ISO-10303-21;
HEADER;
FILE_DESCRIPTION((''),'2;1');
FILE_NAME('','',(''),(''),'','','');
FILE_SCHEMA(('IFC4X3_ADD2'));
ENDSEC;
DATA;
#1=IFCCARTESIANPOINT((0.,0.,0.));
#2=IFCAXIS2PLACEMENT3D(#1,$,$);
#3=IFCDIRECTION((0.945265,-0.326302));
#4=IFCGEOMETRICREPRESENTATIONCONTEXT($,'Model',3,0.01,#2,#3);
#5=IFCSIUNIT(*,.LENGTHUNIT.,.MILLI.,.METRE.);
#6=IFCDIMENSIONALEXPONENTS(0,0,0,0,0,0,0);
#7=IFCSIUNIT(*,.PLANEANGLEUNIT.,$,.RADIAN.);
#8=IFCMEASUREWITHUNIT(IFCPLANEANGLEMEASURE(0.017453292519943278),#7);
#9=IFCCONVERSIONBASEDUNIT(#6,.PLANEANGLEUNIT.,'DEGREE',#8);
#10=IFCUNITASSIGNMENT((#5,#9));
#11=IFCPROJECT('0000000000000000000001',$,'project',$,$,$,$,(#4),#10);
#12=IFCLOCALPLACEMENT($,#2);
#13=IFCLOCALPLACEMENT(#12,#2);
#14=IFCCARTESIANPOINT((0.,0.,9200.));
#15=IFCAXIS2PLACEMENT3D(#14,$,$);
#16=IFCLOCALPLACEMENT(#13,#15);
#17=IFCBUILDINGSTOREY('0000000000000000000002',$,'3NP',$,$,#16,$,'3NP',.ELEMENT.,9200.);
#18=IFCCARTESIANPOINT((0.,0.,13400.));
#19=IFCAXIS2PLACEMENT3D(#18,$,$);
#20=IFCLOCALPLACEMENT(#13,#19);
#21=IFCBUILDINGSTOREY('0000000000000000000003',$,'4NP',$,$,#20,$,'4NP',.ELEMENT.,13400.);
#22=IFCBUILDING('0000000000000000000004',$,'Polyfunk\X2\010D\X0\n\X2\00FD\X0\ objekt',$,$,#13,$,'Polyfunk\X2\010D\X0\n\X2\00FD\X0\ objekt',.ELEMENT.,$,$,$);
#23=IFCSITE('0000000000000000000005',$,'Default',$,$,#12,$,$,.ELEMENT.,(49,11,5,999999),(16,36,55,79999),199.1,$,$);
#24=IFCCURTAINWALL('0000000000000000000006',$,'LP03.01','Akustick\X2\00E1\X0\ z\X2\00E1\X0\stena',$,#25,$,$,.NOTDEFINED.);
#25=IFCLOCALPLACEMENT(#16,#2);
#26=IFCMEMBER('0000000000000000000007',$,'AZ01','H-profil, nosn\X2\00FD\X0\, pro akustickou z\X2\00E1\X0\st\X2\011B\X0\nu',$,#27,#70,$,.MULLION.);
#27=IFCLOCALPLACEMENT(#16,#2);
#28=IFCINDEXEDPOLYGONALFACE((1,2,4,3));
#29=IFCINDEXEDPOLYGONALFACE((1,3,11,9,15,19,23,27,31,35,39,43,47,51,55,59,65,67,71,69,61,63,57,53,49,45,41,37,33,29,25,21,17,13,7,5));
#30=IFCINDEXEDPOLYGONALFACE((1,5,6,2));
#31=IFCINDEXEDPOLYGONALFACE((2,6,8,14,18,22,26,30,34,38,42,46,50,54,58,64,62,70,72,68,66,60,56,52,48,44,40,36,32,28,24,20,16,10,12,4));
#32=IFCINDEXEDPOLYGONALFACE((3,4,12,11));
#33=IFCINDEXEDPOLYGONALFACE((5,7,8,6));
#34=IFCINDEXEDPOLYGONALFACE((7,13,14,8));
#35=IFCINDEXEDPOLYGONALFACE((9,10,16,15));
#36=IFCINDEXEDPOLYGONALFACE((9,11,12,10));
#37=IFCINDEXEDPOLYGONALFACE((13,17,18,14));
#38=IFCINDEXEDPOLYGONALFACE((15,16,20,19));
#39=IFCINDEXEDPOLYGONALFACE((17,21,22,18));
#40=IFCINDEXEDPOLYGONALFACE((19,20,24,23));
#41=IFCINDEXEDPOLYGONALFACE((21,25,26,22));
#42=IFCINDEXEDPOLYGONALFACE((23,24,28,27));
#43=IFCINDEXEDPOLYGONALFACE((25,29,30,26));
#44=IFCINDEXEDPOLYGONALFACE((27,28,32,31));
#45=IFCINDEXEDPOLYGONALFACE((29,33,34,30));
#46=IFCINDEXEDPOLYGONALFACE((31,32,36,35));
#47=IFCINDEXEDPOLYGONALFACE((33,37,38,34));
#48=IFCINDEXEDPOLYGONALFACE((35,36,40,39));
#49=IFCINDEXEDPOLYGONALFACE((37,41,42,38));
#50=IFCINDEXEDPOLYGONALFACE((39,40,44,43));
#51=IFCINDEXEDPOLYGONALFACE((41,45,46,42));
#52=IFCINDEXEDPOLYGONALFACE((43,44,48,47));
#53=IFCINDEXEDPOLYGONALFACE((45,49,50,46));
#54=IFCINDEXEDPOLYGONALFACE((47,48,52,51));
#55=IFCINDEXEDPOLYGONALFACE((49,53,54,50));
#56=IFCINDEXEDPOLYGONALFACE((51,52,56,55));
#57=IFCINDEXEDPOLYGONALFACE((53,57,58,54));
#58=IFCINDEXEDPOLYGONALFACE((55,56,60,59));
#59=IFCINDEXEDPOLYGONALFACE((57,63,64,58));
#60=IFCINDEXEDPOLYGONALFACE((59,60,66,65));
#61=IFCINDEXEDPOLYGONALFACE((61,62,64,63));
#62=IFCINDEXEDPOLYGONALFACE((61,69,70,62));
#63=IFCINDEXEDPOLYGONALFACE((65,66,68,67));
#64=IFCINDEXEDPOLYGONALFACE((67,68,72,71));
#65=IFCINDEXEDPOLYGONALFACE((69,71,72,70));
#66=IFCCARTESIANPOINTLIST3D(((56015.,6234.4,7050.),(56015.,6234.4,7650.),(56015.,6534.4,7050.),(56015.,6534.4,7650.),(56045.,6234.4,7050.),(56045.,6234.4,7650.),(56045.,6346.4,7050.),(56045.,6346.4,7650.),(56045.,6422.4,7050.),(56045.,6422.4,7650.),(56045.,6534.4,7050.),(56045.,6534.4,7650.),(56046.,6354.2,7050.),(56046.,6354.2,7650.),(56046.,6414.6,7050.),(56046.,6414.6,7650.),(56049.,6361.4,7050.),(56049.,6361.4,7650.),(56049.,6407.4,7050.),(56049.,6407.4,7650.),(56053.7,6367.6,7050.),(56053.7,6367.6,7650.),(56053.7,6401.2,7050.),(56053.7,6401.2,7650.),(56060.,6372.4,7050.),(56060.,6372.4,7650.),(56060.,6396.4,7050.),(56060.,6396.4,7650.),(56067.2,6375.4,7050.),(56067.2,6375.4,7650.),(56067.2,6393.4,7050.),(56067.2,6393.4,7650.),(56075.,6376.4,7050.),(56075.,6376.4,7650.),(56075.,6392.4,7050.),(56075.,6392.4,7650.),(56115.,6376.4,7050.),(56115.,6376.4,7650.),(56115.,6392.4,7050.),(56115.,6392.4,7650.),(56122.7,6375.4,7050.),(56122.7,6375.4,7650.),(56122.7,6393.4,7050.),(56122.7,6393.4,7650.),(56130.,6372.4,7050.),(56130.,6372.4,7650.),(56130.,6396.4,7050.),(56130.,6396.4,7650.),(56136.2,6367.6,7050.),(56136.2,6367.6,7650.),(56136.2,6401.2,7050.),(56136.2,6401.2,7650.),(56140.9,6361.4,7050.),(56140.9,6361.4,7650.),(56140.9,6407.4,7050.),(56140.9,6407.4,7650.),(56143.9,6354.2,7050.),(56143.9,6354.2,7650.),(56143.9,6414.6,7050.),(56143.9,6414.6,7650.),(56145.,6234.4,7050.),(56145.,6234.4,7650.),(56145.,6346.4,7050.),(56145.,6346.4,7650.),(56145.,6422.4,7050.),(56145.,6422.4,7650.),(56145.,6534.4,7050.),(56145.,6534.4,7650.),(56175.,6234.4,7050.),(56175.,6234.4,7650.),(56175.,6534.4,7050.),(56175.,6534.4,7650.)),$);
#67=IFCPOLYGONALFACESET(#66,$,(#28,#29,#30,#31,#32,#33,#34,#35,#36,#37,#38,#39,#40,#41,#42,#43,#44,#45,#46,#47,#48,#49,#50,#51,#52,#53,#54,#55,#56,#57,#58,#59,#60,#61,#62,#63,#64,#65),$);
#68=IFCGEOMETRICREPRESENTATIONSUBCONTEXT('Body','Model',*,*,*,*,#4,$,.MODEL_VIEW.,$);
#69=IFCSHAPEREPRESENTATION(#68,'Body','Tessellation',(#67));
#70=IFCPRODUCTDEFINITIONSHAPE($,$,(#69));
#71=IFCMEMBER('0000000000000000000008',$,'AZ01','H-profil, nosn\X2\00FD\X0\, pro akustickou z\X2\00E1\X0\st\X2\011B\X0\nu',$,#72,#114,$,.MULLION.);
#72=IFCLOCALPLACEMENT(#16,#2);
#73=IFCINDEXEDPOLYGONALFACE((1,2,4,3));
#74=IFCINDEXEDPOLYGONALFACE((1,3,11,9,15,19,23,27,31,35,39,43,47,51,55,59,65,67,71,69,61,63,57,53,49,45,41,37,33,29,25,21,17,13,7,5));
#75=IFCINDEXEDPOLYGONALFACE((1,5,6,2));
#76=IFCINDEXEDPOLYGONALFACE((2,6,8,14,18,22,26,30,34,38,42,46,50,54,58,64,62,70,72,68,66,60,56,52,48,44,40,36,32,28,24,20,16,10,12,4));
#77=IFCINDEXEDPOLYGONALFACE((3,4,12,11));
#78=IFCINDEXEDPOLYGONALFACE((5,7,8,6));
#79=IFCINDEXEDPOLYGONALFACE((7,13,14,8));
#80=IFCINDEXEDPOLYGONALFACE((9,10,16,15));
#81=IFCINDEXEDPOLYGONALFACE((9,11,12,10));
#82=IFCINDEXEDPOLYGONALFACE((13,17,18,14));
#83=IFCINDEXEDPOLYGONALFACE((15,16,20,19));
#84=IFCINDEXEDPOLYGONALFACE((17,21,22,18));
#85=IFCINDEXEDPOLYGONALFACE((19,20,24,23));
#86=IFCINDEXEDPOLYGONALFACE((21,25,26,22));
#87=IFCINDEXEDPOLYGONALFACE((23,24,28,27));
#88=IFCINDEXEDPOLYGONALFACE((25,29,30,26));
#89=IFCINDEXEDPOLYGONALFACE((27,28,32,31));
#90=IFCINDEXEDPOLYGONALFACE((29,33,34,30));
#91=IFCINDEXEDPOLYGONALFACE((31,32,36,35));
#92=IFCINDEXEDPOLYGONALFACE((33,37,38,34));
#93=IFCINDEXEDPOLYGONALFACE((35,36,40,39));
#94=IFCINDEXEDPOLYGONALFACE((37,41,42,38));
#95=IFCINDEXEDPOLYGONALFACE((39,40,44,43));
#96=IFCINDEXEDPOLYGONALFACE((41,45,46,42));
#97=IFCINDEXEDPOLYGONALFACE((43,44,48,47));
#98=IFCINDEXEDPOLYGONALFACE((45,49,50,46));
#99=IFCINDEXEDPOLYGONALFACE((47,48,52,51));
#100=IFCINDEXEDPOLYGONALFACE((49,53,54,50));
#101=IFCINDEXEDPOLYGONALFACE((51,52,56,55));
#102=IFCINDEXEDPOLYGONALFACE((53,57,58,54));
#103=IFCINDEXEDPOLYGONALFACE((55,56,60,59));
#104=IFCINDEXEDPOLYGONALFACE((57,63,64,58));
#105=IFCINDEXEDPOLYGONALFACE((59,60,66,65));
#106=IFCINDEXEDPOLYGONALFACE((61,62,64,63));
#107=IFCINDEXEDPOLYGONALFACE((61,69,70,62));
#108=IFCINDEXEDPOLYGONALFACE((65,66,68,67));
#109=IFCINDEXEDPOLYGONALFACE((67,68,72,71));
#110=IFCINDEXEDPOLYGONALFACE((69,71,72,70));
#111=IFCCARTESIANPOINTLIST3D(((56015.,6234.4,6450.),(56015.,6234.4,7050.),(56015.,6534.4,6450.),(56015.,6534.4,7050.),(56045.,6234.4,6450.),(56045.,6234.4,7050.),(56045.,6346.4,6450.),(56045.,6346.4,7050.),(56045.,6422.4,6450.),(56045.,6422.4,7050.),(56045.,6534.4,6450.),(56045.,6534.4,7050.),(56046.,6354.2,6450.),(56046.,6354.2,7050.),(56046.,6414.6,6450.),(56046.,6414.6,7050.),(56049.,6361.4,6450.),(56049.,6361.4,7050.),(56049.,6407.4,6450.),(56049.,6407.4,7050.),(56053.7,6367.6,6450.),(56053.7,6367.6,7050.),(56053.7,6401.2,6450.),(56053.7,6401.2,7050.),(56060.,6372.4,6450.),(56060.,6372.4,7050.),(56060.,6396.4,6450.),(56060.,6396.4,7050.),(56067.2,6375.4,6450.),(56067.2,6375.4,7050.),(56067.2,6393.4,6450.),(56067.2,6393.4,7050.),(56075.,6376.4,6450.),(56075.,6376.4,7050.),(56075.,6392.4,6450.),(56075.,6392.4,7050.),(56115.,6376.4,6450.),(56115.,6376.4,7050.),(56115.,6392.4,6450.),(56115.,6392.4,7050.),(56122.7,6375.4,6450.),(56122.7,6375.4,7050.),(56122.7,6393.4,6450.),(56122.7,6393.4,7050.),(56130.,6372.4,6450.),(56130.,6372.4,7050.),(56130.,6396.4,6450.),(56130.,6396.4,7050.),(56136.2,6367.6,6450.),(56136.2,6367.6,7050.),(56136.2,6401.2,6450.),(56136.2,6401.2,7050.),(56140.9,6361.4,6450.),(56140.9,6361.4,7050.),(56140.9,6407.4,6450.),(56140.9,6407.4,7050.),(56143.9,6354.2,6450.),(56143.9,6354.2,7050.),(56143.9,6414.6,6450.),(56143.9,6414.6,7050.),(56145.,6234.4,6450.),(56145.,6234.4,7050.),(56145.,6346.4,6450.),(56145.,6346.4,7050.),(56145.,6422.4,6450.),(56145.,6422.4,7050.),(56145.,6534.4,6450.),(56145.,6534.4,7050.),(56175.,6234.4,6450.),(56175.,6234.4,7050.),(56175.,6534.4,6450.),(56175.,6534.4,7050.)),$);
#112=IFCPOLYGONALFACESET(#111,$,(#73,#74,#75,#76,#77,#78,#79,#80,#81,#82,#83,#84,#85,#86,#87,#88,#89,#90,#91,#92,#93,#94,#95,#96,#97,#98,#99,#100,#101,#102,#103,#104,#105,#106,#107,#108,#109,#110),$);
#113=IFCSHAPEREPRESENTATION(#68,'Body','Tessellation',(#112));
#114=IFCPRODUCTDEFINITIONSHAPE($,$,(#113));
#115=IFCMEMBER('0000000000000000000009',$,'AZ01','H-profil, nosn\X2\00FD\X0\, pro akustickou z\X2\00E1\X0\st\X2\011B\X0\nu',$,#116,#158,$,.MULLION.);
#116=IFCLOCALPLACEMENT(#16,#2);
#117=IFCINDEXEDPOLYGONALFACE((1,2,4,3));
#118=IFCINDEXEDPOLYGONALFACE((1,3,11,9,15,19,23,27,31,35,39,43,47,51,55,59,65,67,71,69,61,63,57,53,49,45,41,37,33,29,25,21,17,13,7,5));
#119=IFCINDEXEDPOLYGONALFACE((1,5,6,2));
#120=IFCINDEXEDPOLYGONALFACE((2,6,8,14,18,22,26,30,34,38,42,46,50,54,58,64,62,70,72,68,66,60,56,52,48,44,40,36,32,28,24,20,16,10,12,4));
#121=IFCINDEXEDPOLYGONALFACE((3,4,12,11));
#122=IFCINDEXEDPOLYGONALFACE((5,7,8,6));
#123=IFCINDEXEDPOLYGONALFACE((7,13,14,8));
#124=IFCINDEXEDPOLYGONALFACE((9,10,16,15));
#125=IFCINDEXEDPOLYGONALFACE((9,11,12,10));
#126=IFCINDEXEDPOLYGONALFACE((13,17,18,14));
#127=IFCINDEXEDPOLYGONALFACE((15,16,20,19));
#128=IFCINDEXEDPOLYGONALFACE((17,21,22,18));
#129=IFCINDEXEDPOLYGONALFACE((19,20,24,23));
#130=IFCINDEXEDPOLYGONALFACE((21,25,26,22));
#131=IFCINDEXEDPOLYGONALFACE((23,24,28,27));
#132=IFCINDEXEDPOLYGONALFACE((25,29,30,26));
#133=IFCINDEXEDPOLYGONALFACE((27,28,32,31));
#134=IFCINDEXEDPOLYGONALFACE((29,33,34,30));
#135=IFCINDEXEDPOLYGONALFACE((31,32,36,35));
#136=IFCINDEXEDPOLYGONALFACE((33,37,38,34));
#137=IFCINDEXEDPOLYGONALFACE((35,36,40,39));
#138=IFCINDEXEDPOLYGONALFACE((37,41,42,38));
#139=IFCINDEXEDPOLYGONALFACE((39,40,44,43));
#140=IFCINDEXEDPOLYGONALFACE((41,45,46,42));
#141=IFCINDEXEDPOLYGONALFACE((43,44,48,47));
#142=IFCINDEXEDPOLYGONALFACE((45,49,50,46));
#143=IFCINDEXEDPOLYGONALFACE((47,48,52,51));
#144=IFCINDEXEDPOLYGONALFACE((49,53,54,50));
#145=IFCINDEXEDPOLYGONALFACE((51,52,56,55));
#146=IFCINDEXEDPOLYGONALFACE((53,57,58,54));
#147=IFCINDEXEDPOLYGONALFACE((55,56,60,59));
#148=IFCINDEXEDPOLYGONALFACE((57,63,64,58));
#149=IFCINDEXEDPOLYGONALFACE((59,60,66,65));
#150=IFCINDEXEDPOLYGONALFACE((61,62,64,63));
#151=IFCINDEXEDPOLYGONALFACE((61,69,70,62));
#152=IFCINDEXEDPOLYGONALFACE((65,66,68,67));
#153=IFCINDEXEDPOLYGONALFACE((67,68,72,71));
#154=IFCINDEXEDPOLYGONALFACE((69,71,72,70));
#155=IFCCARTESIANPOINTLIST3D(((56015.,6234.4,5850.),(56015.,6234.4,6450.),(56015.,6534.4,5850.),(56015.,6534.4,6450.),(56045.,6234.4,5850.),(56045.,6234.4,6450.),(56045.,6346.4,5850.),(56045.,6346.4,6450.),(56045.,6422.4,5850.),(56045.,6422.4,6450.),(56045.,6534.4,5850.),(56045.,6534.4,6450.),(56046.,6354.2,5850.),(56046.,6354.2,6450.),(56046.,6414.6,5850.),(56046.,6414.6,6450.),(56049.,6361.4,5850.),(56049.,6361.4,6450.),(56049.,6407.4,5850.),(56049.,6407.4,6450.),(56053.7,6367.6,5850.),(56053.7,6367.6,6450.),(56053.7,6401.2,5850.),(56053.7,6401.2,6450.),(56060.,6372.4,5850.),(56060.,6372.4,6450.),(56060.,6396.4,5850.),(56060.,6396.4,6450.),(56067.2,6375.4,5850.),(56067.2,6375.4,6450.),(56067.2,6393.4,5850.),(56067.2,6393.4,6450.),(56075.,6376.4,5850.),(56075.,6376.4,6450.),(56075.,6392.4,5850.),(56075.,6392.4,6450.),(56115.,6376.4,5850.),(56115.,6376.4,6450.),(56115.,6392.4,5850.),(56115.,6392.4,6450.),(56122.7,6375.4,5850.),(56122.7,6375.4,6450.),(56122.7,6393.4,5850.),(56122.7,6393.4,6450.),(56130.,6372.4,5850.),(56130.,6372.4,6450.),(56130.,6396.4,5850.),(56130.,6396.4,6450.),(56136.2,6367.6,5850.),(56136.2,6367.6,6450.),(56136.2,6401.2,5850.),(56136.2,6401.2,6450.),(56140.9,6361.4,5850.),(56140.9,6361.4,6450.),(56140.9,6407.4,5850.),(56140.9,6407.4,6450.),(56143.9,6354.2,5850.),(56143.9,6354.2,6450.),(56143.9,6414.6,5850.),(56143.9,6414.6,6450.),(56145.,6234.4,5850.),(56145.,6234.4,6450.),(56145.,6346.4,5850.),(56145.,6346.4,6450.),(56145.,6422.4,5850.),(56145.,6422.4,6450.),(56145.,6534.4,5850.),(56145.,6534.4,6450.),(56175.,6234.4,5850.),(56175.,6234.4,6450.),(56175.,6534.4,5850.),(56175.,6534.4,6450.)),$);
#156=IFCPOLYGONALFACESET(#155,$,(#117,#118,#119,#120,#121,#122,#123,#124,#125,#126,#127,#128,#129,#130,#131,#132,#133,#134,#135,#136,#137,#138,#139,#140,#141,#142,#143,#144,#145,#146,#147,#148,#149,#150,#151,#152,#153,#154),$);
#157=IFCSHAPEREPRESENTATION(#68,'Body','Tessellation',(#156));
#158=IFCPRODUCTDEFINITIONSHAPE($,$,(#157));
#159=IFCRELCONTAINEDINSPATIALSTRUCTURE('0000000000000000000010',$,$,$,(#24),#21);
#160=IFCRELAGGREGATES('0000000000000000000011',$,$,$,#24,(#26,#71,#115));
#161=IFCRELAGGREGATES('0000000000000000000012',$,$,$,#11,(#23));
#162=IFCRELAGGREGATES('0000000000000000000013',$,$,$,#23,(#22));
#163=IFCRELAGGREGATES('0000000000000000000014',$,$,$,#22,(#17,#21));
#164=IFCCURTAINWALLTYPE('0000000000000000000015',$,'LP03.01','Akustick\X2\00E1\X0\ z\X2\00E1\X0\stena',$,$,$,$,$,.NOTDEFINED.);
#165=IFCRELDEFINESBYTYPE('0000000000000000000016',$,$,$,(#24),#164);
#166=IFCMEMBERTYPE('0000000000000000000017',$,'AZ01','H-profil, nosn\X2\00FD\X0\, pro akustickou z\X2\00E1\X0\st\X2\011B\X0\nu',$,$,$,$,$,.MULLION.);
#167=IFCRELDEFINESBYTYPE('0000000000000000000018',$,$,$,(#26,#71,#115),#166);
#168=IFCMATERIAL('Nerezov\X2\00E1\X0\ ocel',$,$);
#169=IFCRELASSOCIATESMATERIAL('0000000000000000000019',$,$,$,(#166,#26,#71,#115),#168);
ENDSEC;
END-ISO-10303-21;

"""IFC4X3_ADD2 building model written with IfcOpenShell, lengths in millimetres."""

from ifc_helpers import new_model, entity, si_unit, converted_unit, direction, frame, frame_2d, origin, place, context, subcontext, project, spatial, polyline, circle_curve, parameter, trimmed, segment, composite_curve, outline, extrude, source, transform, mapped, material, material_profile, profile_set, profile_usage, type_object, element, aggregate, save


model = new_model("IFC4X3_ADD2")

# Units and contexts
model_context = context("Model", 3, precision=0.01, world=origin(), true_north=direction((0.945265, -0.326302)))
body_context = subcontext(model_context, "Body", "Model", "MODEL_VIEW")
ifc_project = project(units=[si_unit("LENGTHUNIT", "METRE", prefix="MILLI"), converted_unit("PLANEANGLEUNIT", "DEGREE", entity("IfcPlaneAngleMeasure", 0.017453292519943278), si_unit("PLANEANGLEUNIT", "RADIAN"), dimensions=[0, 0, 0, 0, 0, 0, 0])], contexts=[model_context])

# Site, building, storey
site_placement = place(None, origin())
site = spatial("IfcSite", under=ifc_project, at=site_placement, Name="Default", CompositionType="ELEMENT", RefLatitude=(49, 11, 5, 999999), RefLongitude=(16, 36, 55, 79999), RefElevation=199.1)
building_placement = place(site_placement, origin())
building = spatial("IfcBuilding", under=site, at=building_placement, Name="Polyfunkčný objekt", LongName="Polyfunkčný objekt", CompositionType="ELEMENT")
storey_1_placement = place(building_placement, frame((0.0, 0.0, 9200.0)))
storey_1 = spatial("IfcBuildingStorey", under=building, at=storey_1_placement, Name="3NP", LongName="3NP", CompositionType="ELEMENT", Elevation=9200.0)

# Shared definitions
storey_2_placement = place(building_placement, frame((0.0, 0.0, 13400.0)))
storey_2 = spatial("IfcBuildingStorey", under=building, at=storey_2_placement, Name="4NP", LongName="4NP", CompositionType="ELEMENT", Elevation=13400.0)

# Curtain wall, members
curtain_wall_type_1 = type_object("IfcCurtainWallType", Name="LP03.01", Description="Akustická zástena", PredefinedType="NOTDEFINED")
ifc_material_1 = material(Name="Nerezová ocel")
ifc_material_profile_1 = material_profile(ifc_material_1, outline(composite_curve([segment(polyline([(50.0, -150.0), (80.0, -150.0)]), True, "CONTINUOUS"), segment(polyline([(80.0, -150.0), (80.0, 150.0)]), True, "CONTINUOUS"), segment(polyline([(80.0, 150.0), (50.0, 150.0)]), True, "CONTINUOUS"), segment(polyline([(50.0, 150.0), (50.0, 38.0)]), True, "CONTINUOUS"), segment(trimmed(circle_curve(frame_2d((20.0, 38.0), x_axis=(0.0, 1.0)), 30.0), [parameter(180.0)], [parameter(270.0)], True, "PARAMETER"), False, "CONTINUOUS"), segment(polyline([(20.0, 8.0), (-20.0, 8.0)]), True, "CONTINUOUS"), segment(trimmed(circle_curve(frame_2d((-20.0, 38.0), x_axis=(0.0, 1.0)), 30.0), [parameter(90.0)], [parameter(180.0)], True, "PARAMETER"), False, "CONTINUOUS"), segment(polyline([(-50.0, 38.0), (-50.0, 150.0)]), True, "CONTINUOUS"), segment(polyline([(-50.0, 150.0), (-80.0, 150.0)]), True, "CONTINUOUS"), segment(polyline([(-80.0, 150.0), (-80.0, -150.0)]), True, "CONTINUOUS"), segment(polyline([(-80.0, -150.0), (-50.0, -150.0)]), True, "CONTINUOUS"), segment(polyline([(-50.0, -150.0), (-50.0, -38.0)]), True, "CONTINUOUS"), segment(trimmed(circle_curve(frame_2d((-20.0, -38.0), x_axis=(0.0, 1.0)), 30.0), [parameter(0.0)], [parameter(90.0)], True, "PARAMETER"), False, "CONTINUOUS"), segment(polyline([(-20.0, -8.0), (20.0, -8.0)]), True, "CONTINUOUS"), segment(trimmed(circle_curve(frame_2d((20.0, -38.0), x_axis=(0.0, 1.0)), 30.0), [parameter(270.0)], [parameter(0.0)], True, "PARAMETER"), False, "CONTINUOUS"), segment(polyline([(50.0, -38.0), (50.0, -150.0)]), True, "CONTINUOUS")], self_intersect=False)), Name="Profil zástena")
ifc_profile_set_1 = profile_set([ifc_material_profile_1], Name="Profil zástena")
ifc_profile_usage_1 = profile_usage(ifc_profile_set_1)
member_type_1 = type_object("IfcMemberType", Name="AZ01", Description="H-profil, nosný, pro akustickou zástěnu", PredefinedType="MULLION", material=ifc_profile_set_1)
curtain_wall_1_placement = place(storey_2_placement, frame((0.0, 0.0, -13400.0)))
curtain_wall_1 = element("IfcCurtainWall", 1, at=curtain_wall_1_placement, inside=storey_2, type_object=curtain_wall_type_1, Name="LP03.01", Description="Akustická zástena", PredefinedType="NOTDEFINED")
shared_shape_1 = source(origin(), body_context, "Body", "SweptSolid", [
    extrude(outline(composite_curve([segment(polyline([(-150.0, -50.0), (-150.0, -80.0)]), True, "CONTINUOUS"), segment(polyline([(-150.0, -80.0), (150.0, -80.0)]), True, "CONTINUOUS"), segment(polyline([(150.0, -80.0), (150.0, -50.0)]), True, "CONTINUOUS"), segment(polyline([(150.0, -50.0), (38.0, -50.0)]), True, "CONTINUOUS"), segment(trimmed(circle_curve(frame_2d((38.0, -20.0), x_axis=(1.0, 0.0)), 30.0), [parameter(180.0)], [parameter(270.0)], True, "PARAMETER"), False, "CONTINUOUS"), segment(polyline([(8.0, -20.0), (8.0, 20.0)]), True, "CONTINUOUS"), segment(trimmed(circle_curve(frame_2d((38.0, 20.0), x_axis=(1.0, 0.0)), 30.0), [parameter(90.0)], [parameter(180.0)], True, "PARAMETER"), False, "CONTINUOUS"), segment(polyline([(38.0, 50.0), (150.0, 50.0)]), True, "CONTINUOUS"), segment(polyline([(150.0, 50.0), (150.0, 80.0)]), True, "CONTINUOUS"), segment(polyline([(150.0, 80.0), (-150.0, 80.0)]), True, "CONTINUOUS"), segment(polyline([(-150.0, 80.0), (-150.0, 50.0)]), True, "CONTINUOUS"), segment(polyline([(-150.0, 50.0), (-38.0, 50.0)]), True, "CONTINUOUS"), segment(trimmed(circle_curve(frame_2d((-38.0, 20.0), x_axis=(1.0, 0.0)), 30.0), [parameter(0.0)], [parameter(90.0)], True, "PARAMETER"), False, "CONTINUOUS"), segment(polyline([(-8.0, 20.0), (-8.0, -20.0)]), True, "CONTINUOUS"), segment(trimmed(circle_curve(frame_2d((-38.0, -20.0), x_axis=(1.0, 0.0)), 30.0), [parameter(270.0)], [parameter(0.0)], True, "PARAMETER"), False, "CONTINUOUS"), segment(polyline([(-38.0, -50.0), (-150.0, -50.0)]), True, "CONTINUOUS")], self_intersect=False)), frame((-150.0, 0.0, -600.0), z_axis=(0.0, 0.0, -1.0), x_axis=(1.0, 0.0, 0.0)), (0.0, 0.0, -1.0), 600.0),
])
member_1_placement = place(curtain_wall_1_placement, frame((56095.0, 6534.4, 16250.0), z_axis=(0.0, 0.0, -1.0), x_axis=(0.0, 1.0, 0.0)))
member_1 = element("IfcMember", 2, at=member_1_placement, type_object=member_type_1, material=ifc_profile_usage_1, Name="AZ01", Description="H-profil, nosný, pro akustickou zástěnu", PredefinedType="MULLION", context=body_context, shape_type="MappedRepresentation", body=[
    mapped(shared_shape_1, transform((0.0, 0.0, 0.0), scale=1.0)),
])
member_2_placement = place(curtain_wall_1_placement, frame((56095.0, 6534.4, 15650.0), z_axis=(0.0, 0.0, -1.0), x_axis=(0.0, 1.0, 0.0)))
member_2 = element("IfcMember", 3, at=member_2_placement, type_object=member_type_1, material=ifc_profile_usage_1, Name="AZ01", Description="H-profil, nosný, pro akustickou zástěnu", PredefinedType="MULLION", context=body_context, shape_type="MappedRepresentation", body=[
    mapped(shared_shape_1, transform((0.0, 0.0, 0.0), scale=1.0)),
])
member_3_placement = place(curtain_wall_1_placement, frame((56095.0, 6534.4, 15050.0), z_axis=(0.0, 0.0, -1.0), x_axis=(0.0, 1.0, 0.0)))
member_3 = element("IfcMember", 4, at=member_3_placement, type_object=member_type_1, material=ifc_profile_usage_1, Name="AZ01", Description="H-profil, nosný, pro akustickou zástěnu", PredefinedType="MULLION", context=body_context, shape_type="MappedRepresentation", body=[
    mapped(shared_shape_1, transform((0.0, 0.0, 0.0), scale=1.0)),
])

aggregate(curtain_wall_1, [member_1, member_2, member_3])

save(model, "model.ifc")
